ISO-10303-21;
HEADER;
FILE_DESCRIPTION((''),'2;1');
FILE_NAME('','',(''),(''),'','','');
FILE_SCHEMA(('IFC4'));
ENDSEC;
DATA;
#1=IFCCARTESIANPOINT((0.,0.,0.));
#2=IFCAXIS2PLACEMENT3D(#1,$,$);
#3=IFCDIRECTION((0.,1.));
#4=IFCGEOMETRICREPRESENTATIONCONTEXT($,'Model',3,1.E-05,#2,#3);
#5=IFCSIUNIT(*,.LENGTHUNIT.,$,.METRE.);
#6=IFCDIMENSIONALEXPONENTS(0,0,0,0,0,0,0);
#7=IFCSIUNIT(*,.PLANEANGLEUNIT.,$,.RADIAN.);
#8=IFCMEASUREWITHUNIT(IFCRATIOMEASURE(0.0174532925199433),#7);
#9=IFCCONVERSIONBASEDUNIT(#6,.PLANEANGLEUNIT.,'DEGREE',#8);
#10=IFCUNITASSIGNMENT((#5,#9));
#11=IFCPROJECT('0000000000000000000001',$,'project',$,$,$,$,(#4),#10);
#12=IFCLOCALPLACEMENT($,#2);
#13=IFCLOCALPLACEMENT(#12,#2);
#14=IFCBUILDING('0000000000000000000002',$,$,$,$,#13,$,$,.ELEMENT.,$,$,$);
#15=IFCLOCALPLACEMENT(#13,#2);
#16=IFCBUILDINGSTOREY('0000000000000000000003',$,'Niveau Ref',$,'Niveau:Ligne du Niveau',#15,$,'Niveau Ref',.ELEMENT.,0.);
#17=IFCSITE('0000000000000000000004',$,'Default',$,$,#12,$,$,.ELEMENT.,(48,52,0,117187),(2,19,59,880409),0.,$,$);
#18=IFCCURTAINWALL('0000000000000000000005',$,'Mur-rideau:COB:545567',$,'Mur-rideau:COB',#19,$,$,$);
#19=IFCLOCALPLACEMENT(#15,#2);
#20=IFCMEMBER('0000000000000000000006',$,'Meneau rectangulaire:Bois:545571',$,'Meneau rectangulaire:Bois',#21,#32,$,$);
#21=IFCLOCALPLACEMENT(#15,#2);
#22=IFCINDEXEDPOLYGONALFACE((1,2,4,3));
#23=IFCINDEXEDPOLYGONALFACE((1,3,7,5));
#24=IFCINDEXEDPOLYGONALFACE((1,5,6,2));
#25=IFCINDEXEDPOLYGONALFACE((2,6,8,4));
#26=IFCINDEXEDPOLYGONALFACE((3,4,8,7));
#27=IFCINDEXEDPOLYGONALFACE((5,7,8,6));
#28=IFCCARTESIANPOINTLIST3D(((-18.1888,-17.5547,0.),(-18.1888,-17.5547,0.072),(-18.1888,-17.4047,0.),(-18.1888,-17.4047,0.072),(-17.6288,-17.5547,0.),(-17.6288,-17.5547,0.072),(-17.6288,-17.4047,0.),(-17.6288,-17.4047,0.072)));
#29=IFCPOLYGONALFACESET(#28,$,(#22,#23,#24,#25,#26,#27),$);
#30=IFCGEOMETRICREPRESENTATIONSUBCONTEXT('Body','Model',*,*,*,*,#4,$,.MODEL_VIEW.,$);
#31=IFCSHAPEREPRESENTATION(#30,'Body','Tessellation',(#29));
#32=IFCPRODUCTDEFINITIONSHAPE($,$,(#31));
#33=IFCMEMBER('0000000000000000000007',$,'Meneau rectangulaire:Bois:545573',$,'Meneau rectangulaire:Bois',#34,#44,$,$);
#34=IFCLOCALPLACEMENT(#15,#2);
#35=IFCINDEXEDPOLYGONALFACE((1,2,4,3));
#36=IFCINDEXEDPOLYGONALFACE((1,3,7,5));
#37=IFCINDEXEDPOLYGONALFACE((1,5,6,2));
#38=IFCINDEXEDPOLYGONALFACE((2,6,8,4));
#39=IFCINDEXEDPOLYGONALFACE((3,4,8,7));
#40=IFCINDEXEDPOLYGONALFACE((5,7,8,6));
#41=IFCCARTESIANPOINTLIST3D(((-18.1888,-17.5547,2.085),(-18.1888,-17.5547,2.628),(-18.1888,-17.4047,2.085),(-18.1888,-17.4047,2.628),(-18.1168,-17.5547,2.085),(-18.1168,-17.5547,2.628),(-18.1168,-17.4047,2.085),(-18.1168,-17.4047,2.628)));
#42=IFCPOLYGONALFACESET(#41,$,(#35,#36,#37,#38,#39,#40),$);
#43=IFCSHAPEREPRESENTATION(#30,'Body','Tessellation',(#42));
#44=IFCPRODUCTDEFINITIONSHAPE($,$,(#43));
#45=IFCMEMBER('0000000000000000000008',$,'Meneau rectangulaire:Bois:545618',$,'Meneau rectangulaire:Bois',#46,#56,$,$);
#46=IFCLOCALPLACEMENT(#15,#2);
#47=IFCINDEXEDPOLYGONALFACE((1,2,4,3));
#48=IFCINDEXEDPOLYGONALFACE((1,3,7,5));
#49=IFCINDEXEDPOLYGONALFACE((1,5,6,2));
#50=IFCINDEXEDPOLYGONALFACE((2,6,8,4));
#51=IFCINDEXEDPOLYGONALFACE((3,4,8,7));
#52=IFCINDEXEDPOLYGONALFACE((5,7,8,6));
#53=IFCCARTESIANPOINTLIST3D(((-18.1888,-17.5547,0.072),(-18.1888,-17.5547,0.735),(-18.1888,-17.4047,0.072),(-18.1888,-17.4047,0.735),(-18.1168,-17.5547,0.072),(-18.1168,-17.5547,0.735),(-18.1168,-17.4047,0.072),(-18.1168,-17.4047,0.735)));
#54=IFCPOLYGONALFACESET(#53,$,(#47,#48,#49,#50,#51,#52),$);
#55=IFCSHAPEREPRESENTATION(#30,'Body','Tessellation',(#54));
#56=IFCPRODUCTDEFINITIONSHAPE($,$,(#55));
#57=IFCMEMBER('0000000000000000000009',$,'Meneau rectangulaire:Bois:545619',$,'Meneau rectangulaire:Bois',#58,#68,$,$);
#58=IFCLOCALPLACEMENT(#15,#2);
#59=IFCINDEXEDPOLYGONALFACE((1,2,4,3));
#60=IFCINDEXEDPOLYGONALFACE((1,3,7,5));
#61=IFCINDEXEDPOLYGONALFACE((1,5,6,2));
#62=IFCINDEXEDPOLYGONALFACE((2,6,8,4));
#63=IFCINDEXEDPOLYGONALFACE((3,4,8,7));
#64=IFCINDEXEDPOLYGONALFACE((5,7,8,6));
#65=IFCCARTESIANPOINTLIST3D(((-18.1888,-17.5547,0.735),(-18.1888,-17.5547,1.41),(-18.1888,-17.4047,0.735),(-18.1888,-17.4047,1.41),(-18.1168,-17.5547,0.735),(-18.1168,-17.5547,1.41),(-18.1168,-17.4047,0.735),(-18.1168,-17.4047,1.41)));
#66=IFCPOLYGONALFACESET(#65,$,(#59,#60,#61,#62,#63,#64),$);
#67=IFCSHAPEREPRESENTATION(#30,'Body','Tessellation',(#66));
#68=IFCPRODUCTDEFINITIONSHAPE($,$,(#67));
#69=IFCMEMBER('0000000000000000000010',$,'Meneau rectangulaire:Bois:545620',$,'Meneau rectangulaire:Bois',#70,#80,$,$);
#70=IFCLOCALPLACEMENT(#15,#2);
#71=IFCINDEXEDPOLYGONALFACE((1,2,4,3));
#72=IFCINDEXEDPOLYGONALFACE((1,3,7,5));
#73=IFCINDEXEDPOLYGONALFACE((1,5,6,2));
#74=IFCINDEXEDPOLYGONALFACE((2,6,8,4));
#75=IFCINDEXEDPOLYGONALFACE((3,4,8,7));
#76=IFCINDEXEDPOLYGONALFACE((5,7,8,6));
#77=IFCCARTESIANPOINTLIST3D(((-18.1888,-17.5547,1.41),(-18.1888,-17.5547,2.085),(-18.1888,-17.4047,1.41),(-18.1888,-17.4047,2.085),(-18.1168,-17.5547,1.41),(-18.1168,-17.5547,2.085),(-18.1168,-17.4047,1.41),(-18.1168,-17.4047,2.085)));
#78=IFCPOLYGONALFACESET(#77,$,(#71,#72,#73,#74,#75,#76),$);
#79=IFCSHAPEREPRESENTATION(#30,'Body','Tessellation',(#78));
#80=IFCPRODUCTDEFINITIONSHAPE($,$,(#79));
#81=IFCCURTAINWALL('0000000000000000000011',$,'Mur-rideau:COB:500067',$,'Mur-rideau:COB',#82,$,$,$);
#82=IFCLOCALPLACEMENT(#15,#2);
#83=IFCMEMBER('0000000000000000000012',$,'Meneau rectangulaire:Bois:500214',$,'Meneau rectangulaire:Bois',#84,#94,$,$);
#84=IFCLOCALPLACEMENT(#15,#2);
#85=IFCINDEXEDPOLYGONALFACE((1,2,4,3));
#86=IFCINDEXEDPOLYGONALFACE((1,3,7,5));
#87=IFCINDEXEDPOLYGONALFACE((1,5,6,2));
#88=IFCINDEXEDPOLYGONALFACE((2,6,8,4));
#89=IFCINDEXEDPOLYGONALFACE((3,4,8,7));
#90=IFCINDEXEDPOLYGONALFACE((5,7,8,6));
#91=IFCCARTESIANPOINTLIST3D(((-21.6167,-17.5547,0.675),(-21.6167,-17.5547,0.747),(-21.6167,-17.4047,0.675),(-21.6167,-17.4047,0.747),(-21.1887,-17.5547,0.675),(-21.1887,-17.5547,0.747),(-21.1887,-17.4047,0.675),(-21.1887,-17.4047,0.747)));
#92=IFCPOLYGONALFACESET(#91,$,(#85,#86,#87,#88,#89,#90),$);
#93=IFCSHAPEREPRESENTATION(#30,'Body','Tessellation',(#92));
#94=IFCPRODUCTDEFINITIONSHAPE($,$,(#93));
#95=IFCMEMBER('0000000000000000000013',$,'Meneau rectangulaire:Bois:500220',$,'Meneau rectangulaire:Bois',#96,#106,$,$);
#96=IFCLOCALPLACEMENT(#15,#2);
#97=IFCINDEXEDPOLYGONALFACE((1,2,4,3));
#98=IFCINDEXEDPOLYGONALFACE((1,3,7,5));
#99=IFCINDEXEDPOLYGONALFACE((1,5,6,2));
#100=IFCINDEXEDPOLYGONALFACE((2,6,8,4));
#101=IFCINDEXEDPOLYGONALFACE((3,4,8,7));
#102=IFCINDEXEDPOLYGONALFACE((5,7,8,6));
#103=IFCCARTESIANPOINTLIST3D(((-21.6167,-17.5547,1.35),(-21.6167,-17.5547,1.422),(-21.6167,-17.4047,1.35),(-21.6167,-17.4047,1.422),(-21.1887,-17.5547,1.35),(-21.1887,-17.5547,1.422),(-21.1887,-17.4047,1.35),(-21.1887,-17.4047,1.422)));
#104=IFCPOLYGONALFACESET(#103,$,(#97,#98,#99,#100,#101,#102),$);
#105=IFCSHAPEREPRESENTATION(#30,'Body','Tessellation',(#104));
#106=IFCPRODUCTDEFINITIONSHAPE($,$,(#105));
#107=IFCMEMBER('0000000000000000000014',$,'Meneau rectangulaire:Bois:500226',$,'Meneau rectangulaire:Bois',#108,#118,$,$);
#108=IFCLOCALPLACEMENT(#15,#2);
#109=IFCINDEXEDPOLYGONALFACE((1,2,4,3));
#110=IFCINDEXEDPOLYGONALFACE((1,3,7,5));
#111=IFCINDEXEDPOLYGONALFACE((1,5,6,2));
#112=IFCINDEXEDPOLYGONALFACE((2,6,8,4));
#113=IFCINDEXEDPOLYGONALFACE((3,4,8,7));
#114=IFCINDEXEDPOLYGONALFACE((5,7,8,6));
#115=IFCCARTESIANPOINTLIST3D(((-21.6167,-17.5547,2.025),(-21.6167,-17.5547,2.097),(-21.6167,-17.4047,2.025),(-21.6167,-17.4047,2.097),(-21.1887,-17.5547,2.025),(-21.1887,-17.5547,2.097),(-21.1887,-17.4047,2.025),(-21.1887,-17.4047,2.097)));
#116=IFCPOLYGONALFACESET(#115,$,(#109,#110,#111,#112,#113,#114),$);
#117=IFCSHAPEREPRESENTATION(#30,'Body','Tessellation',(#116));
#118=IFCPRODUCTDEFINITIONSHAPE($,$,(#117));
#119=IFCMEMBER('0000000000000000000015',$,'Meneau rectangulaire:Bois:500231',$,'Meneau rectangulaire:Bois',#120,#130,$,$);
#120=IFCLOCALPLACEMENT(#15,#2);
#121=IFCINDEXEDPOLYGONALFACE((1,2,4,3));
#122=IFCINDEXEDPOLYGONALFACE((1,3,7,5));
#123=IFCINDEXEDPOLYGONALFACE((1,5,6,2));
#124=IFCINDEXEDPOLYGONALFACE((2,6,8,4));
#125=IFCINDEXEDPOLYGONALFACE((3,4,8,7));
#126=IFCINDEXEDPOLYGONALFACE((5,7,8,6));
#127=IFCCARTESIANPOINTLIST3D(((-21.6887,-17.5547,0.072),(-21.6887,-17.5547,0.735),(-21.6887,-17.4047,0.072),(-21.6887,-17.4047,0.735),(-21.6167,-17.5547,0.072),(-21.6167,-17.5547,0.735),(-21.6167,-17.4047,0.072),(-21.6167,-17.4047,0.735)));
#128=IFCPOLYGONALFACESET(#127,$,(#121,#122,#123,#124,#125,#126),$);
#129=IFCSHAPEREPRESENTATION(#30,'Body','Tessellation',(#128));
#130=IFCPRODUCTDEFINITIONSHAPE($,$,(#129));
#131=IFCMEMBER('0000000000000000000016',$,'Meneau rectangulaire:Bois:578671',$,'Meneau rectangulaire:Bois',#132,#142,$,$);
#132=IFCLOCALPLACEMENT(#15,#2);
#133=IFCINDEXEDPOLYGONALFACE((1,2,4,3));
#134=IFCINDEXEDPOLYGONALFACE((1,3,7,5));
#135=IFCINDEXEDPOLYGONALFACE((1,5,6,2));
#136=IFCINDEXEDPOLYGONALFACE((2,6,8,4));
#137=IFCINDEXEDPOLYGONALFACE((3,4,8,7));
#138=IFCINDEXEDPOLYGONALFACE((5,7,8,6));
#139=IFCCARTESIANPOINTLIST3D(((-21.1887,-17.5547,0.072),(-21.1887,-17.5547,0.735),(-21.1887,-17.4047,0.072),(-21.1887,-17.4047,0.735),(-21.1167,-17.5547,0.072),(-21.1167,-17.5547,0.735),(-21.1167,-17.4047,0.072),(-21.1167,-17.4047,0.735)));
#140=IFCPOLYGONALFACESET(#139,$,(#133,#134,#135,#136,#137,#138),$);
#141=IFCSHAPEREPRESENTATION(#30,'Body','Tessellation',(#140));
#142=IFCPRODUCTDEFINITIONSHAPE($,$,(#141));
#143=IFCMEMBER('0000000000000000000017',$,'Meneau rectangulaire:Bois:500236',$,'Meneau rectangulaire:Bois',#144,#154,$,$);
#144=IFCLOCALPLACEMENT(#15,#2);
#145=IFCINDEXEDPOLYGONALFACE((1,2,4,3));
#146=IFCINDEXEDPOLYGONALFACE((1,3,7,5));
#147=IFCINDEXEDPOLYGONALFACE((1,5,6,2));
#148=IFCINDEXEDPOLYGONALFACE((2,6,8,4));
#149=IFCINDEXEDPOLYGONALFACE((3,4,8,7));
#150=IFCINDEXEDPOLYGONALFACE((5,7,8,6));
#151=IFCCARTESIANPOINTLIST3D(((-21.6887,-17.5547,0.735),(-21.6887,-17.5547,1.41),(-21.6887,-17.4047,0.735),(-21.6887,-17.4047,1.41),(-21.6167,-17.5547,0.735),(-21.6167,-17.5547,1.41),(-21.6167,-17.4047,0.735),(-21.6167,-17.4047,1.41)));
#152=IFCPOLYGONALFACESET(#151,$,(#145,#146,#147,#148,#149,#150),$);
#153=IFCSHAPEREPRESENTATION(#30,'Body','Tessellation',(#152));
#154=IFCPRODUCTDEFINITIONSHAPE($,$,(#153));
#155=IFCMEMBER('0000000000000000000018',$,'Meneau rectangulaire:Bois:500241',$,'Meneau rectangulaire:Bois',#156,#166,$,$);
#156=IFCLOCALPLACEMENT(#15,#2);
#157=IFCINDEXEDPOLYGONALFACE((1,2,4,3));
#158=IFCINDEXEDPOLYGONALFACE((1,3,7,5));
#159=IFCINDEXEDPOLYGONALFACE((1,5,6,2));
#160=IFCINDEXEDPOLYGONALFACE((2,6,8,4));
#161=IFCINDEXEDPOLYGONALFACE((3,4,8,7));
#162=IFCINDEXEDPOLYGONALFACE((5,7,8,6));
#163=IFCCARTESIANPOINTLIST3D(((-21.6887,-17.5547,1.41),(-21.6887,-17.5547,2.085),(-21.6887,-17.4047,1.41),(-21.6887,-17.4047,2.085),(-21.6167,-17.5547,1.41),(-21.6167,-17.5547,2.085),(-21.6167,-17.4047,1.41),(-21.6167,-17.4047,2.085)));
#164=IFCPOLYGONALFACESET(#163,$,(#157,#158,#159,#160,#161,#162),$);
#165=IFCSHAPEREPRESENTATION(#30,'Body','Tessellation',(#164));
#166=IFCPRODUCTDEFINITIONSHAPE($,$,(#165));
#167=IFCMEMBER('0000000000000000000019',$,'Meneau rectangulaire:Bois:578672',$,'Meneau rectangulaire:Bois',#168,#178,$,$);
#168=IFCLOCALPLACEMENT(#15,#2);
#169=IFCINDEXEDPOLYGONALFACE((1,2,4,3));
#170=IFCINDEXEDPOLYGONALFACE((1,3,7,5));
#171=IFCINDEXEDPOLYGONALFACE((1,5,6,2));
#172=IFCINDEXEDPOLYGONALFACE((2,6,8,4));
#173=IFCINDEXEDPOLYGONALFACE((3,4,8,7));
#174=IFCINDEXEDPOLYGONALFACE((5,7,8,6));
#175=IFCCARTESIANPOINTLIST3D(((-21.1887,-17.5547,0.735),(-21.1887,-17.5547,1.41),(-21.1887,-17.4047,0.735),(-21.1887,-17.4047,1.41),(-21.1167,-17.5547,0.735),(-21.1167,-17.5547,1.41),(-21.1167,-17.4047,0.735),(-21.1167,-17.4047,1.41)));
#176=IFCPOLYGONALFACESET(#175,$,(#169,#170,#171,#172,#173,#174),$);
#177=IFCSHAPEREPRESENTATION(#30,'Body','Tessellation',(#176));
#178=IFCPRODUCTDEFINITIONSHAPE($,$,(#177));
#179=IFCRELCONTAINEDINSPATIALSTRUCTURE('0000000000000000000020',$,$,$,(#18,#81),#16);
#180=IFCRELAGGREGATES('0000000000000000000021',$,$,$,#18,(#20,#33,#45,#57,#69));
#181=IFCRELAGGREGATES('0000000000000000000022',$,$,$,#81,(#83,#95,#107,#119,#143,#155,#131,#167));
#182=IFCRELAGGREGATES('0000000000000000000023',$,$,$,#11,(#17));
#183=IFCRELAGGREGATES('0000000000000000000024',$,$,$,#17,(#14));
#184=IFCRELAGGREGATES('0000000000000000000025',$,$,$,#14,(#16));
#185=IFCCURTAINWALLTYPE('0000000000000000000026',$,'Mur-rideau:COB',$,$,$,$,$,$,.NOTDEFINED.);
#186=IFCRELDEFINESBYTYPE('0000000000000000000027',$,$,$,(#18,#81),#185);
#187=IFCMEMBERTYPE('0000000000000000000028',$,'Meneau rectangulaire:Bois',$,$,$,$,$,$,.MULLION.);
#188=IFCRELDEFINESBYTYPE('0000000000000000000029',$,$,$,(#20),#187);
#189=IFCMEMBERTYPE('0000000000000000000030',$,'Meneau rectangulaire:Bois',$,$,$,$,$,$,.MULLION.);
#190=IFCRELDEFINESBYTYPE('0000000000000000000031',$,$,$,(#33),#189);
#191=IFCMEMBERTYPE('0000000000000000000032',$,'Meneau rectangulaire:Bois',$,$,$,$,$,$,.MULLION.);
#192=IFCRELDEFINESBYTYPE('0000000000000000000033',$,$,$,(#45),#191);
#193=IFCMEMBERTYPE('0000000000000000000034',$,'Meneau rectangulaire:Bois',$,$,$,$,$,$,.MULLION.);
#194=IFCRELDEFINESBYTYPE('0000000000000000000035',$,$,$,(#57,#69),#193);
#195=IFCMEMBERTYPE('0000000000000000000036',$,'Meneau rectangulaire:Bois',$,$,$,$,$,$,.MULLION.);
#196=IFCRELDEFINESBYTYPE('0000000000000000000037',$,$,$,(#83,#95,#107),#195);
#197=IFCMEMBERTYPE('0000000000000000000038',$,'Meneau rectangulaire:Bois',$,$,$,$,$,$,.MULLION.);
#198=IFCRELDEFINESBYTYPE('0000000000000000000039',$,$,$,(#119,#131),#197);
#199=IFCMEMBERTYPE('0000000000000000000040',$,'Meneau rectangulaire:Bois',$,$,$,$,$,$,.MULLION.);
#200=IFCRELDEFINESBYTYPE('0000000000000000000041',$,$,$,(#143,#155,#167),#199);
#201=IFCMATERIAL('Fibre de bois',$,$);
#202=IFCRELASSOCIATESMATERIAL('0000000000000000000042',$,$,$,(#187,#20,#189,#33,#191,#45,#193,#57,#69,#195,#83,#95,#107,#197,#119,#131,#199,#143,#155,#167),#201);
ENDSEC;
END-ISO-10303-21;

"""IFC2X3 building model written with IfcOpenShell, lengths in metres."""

from ifc_helpers import new_model, entity, si_unit, converted_unit, direction, frame, origin, origin_2d_with_axis, place, context, subcontext, project, spatial, rectangle, extrude, source, transform, mapped, material, type_object, type_shapes, element, aggregate, save


model = new_model("IFC2X3")

# Units and contexts
model_context = context("Model", 3, precision=1e-05, world=origin(), true_north=direction((0.0, 1.0)))
body_context = subcontext(model_context, "Body", "Model", "MODEL_VIEW")
ifc_project = project(units=[si_unit("LENGTHUNIT", "METRE"), converted_unit("PLANEANGLEUNIT", "DEGREE", entity("IfcRatioMeasure", 0.0174532925199433), si_unit("PLANEANGLEUNIT", "RADIAN"), dimensions=[0, 0, 0, 0, 0, 0, 0])], contexts=[model_context])

# Site, building, storey
site_placement = place(None, origin())
site = spatial("IfcSite", under=ifc_project, at=site_placement, Name="Default", CompositionType="ELEMENT", RefLatitude=(48, 52, 0, 117187), RefLongitude=(2, 19, 59, 880409), RefElevation=0.0)
building_placement = place(site_placement, origin())
building = spatial("IfcBuilding", under=site, at=building_placement, CompositionType="ELEMENT")
storey_placement = place(building_placement, origin())
storey = spatial("IfcBuildingStorey", under=building, at=storey_placement, Name="Niveau Ref", ObjectType="Niveau:Ligne du Niveau", LongName="Niveau Ref", CompositionType="ELEMENT", Elevation=0.0)

# Curtain walls, members
curtain_wall_type_1 = type_object("IfcCurtainWallType", Name="Mur-rideau:COB", PredefinedType="NOTDEFINED")
curtain_wall_1_placement = place(storey_placement, origin())
curtain_wall_1 = element("IfcCurtainWall", 1, at=curtain_wall_1_placement, inside=storey, type_object=curtain_wall_type_1, Name="Mur-rideau:COB:545567", ObjectType="Mur-rideau:COB")
ifc_material_1 = material(Name="Fibre de bois")
member_type_1 = type_object("IfcMemberType", Name="Meneau rectangulaire:Bois", PredefinedType="MULLION", material=ifc_material_1)
shared_shape_1 = source(origin(), body_context, "Body", "SweptSolid", [
    extrude(rectangle(XDim=0.15, YDim=0.072, at=origin_2d_with_axis()), frame((-0.036, 0.0, -0.56), z_axis=(0.0, 0.0, 1.0), x_axis=(0.0, -1.0, 0.0)), (0.0, 0.0, 1.0), 0.56),
])
type_shapes(member_type_1, [shared_shape_1])
member_1_placement = place(storey_placement, frame((-18.1888, -17.4797, 0.0), z_axis=(-1.0, 0.0, 0.0), x_axis=(0.0, 0.0, -1.0)))
member_1 = element("IfcMember", 2, at=member_1_placement, type_object=member_type_1, material=ifc_material_1, Name="Meneau rectangulaire:Bois:545571", ObjectType="Meneau rectangulaire:Bois", context=body_context, shape_type="MappedRepresentation", body=[
    mapped(shared_shape_1, transform((0.0, 0.0, 0.0), scale=1.0)),
])
member_type_2 = type_object("IfcMemberType", Name="Meneau rectangulaire:Bois", PredefinedType="MULLION", material=ifc_material_1)
shared_shape_2 = source(origin(), body_context, "Body", "SweptSolid", [
    extrude(rectangle(XDim=0.15, YDim=0.072, at=origin_2d_with_axis()), frame((-0.036, 0.0, -0.543), z_axis=(0.0, 0.0, 1.0), x_axis=(0.0, -1.0, 0.0)), (0.0, 0.0, 1.0), 0.543),
])
type_shapes(member_type_2, [shared_shape_2])
member_2_placement = place(storey_placement, frame((-18.1888, -17.4797, 2.628), z_axis=(0.0, 0.0, 1.0), x_axis=(-1.0, 0.0, 0.0)))
member_2 = element("IfcMember", 3, at=member_2_placement, type_object=member_type_2, material=ifc_material_1, Name="Meneau rectangulaire:Bois:545573", ObjectType="Meneau rectangulaire:Bois", context=body_context, shape_type="MappedRepresentation", body=[
    mapped(shared_shape_2, transform((0.0, 0.0, 0.0), scale=1.0)),
])
member_type_3 = type_object("IfcMemberType", Name="Meneau rectangulaire:Bois", PredefinedType="MULLION", material=ifc_material_1)
shared_shape_3 = source(origin(), body_context, "Body", "SweptSolid", [
    extrude(rectangle(XDim=0.15, YDim=0.072, at=origin_2d_with_axis()), frame((-0.036, 0.0, -0.663), z_axis=(0.0, 0.0, 1.0), x_axis=(0.0, -1.0, 0.0)), (0.0, 0.0, 1.0), 0.663),
])
type_shapes(member_type_3, [shared_shape_3])
member_3_placement = place(storey_placement, frame((-18.1888, -17.4797, 0.735), z_axis=(0.0, 0.0, 1.0), x_axis=(-1.0, 0.0, 0.0)))
member_3 = element("IfcMember", 4, at=member_3_placement, type_object=member_type_3, material=ifc_material_1, Name="Meneau rectangulaire:Bois:545618", ObjectType="Meneau rectangulaire:Bois", context=body_context, shape_type="MappedRepresentation", body=[
    mapped(shared_shape_3, transform((0.0, 0.0, 0.0), scale=1.0)),
])
member_type_4 = type_object("IfcMemberType", Name="Meneau rectangulaire:Bois", PredefinedType="MULLION", material=ifc_material_1)
shared_shape_4 = source(origin(), body_context, "Body", "SweptSolid", [
    extrude(rectangle(XDim=0.15, YDim=0.072, at=origin_2d_with_axis()), frame((-0.036, 0.0, -0.675), z_axis=(0.0, 0.0, 1.0), x_axis=(0.0, -1.0, 0.0)), (0.0, 0.0, 1.0), 0.675),
])
type_shapes(member_type_4, [shared_shape_4])
member_4_placement = place(storey_placement, frame((-18.1888, -17.4797, 1.41), z_axis=(0.0, 0.0, 1.0), x_axis=(-1.0, 0.0, 0.0)))
member_4 = element("IfcMember", 5, at=member_4_placement, type_object=member_type_4, material=ifc_material_1, Name="Meneau rectangulaire:Bois:545619", ObjectType="Meneau rectangulaire:Bois", context=body_context, shape_type="MappedRepresentation", body=[
    mapped(shared_shape_4, transform((0.0, 0.0, 0.0), scale=1.0)),
])
member_5_placement = place(storey_placement, frame((-18.1888, -17.4797, 2.085), z_axis=(0.0, 0.0, 1.0), x_axis=(-1.0, 0.0, 0.0)))
member_5 = element("IfcMember", 6, at=member_5_placement, type_object=member_type_4, material=ifc_material_1, Name="Meneau rectangulaire:Bois:545620", ObjectType="Meneau rectangulaire:Bois", context=body_context, shape_type="MappedRepresentation", body=[
    mapped(shared_shape_4, transform((0.0, 0.0, 0.0), scale=1.0)),
])
aggregate(curtain_wall_1, [member_1, member_2, member_3, member_4, member_5])
curtain_wall_2_placement = place(storey_placement, origin())
curtain_wall_2 = element("IfcCurtainWall", 7, at=curtain_wall_2_placement, inside=storey, type_object=curtain_wall_type_1, Name="Mur-rideau:COB:500067", ObjectType="Mur-rideau:COB")
member_type_5 = type_object("IfcMemberType", Name="Meneau rectangulaire:Bois", PredefinedType="MULLION", material=ifc_material_1)
shared_shape_5 = source(origin(), body_context, "Body", "SweptSolid", [
    extrude(rectangle(XDim=0.15, YDim=0.072, at=origin_2d_with_axis()), frame((-0.024, 0.0, -0.428), z_axis=(0.0, 0.0, 1.0), x_axis=(0.0, -1.0, 0.0)), (0.0, 0.0, 1.0), 0.428),
])
type_shapes(member_type_5, [shared_shape_5])
member_6_placement = place(storey_placement, frame((-21.1887, -17.4797, 0.735), z_axis=(1.0, 0.0, 0.0), x_axis=(0.0, 0.0, 1.0)))
member_6 = element("IfcMember", 8, at=member_6_placement, type_object=member_type_5, material=ifc_material_1, Name="Meneau rectangulaire:Bois:500214", ObjectType="Meneau rectangulaire:Bois", context=body_context, shape_type="MappedRepresentation", body=[
    mapped(shared_shape_5, transform((0.0, 0.0, 0.0), scale=1.0)),
])
member_7_placement = place(storey_placement, frame((-21.1887, -17.4797, 1.41), z_axis=(1.0, 0.0, 0.0), x_axis=(0.0, 0.0, 1.0)))
member_7 = element("IfcMember", 9, at=member_7_placement, type_object=member_type_5, material=ifc_material_1, Name="Meneau rectangulaire:Bois:500220", ObjectType="Meneau rectangulaire:Bois", context=body_context, shape_type="MappedRepresentation", body=[
    mapped(shared_shape_5, transform((0.0, 0.0, 0.0), scale=1.0)),
])
member_8_placement = place(storey_placement, frame((-21.1887, -17.4797, 2.085), z_axis=(1.0, 0.0, 0.0), x_axis=(0.0, 0.0, 1.0)))
member_8 = element("IfcMember", 10, at=member_8_placement, type_object=member_type_5, material=ifc_material_1, Name="Meneau rectangulaire:Bois:500226", ObjectType="Meneau rectangulaire:Bois", context=body_context, shape_type="MappedRepresentation", body=[
    mapped(shared_shape_5, transform((0.0, 0.0, 0.0), scale=1.0)),
])
member_type_6 = type_object("IfcMemberType", Name="Meneau rectangulaire:Bois", PredefinedType="MULLION", material=ifc_material_1)
shared_shape_6 = source(origin(), body_context, "Body", "SweptSolid", [
    extrude(rectangle(XDim=0.15, YDim=0.072, at=origin_2d_with_axis()), frame((-0.024, 0.0, -0.663), z_axis=(0.0, 0.0, 1.0), x_axis=(0.0, -1.0, 0.0)), (0.0, 0.0, 1.0), 0.663),
])
type_shapes(member_type_6, [shared_shape_6])
member_9_placement = place(storey_placement, frame((-21.6287, -17.4797, 0.072), z_axis=(0.0, 0.0, -1.0), x_axis=(1.0, 0.0, 0.0)))
member_9 = element("IfcMember", 11, at=member_9_placement, type_object=member_type_6, material=ifc_material_1, Name="Meneau rectangulaire:Bois:500231", ObjectType="Meneau rectangulaire:Bois", context=body_context, shape_type="MappedRepresentation", body=[
    mapped(shared_shape_6, transform((0.0, 0.0, 0.0), scale=1.0)),
])
member_10_placement = place(storey_placement, frame((-21.1287, -17.4797, 0.072), z_axis=(0.0, 0.0, -1.0), x_axis=(1.0, 0.0, 0.0)))
member_10 = element("IfcMember", 12, at=member_10_placement, type_object=member_type_6, material=ifc_material_1, Name="Meneau rectangulaire:Bois:578671", ObjectType="Meneau rectangulaire:Bois", context=body_context, shape_type="MappedRepresentation", body=[
    mapped(shared_shape_6, transform((0.0, 0.0, 0.0), scale=1.0)),
])
member_type_7 = type_object("IfcMemberType", Name="Meneau rectangulaire:Bois", PredefinedType="MULLION", material=ifc_material_1)
shared_shape_7 = source(origin(), body_context, "Body", "SweptSolid", [
    extrude(rectangle(XDim=0.15, YDim=0.072, at=origin_2d_with_axis()), frame((-0.024, 0.0, -0.675), z_axis=(0.0, 0.0, 1.0), x_axis=(0.0, -1.0, 0.0)), (0.0, 0.0, 1.0), 0.675),
])
type_shapes(member_type_7, [shared_shape_7])
member_11_placement = place(storey_placement, frame((-21.6287, -17.4797, 0.735), z_axis=(0.0, 0.0, -1.0), x_axis=(1.0, 0.0, 0.0)))
member_11 = element("IfcMember", 13, at=member_11_placement, type_object=member_type_7, material=ifc_material_1, Name="Meneau rectangulaire:Bois:500236", ObjectType="Meneau rectangulaire:Bois", context=body_context, shape_type="MappedRepresentation", body=[
    mapped(shared_shape_7, transform((0.0, 0.0, 0.0), scale=1.0)),
])
member_12_placement = place(storey_placement, frame((-21.6287, -17.4797, 1.41), z_axis=(0.0, 0.0, -1.0), x_axis=(1.0, 0.0, 0.0)))
member_12 = element("IfcMember", 14, at=member_12_placement, type_object=member_type_7, material=ifc_material_1, Name="Meneau rectangulaire:Bois:500241", ObjectType="Meneau rectangulaire:Bois", context=body_context, shape_type="MappedRepresentation", body=[
    mapped(shared_shape_7, transform((0.0, 0.0, 0.0), scale=1.0)),
])
member_13_placement = place(storey_placement, frame((-21.1287, -17.4797, 0.735), z_axis=(0.0, 0.0, -1.0), x_axis=(1.0, 0.0, 0.0)))
member_13 = element("IfcMember", 15, at=member_13_placement, type_object=member_type_7, material=ifc_material_1, Name="Meneau rectangulaire:Bois:578672", ObjectType="Meneau rectangulaire:Bois", context=body_context, shape_type="MappedRepresentation", body=[
    mapped(shared_shape_7, transform((0.0, 0.0, 0.0), scale=1.0)),
])
aggregate(curtain_wall_2, [member_6, member_7, member_8, member_9, member_11, member_12, member_10, member_13])

save(model, "model.ifc")
